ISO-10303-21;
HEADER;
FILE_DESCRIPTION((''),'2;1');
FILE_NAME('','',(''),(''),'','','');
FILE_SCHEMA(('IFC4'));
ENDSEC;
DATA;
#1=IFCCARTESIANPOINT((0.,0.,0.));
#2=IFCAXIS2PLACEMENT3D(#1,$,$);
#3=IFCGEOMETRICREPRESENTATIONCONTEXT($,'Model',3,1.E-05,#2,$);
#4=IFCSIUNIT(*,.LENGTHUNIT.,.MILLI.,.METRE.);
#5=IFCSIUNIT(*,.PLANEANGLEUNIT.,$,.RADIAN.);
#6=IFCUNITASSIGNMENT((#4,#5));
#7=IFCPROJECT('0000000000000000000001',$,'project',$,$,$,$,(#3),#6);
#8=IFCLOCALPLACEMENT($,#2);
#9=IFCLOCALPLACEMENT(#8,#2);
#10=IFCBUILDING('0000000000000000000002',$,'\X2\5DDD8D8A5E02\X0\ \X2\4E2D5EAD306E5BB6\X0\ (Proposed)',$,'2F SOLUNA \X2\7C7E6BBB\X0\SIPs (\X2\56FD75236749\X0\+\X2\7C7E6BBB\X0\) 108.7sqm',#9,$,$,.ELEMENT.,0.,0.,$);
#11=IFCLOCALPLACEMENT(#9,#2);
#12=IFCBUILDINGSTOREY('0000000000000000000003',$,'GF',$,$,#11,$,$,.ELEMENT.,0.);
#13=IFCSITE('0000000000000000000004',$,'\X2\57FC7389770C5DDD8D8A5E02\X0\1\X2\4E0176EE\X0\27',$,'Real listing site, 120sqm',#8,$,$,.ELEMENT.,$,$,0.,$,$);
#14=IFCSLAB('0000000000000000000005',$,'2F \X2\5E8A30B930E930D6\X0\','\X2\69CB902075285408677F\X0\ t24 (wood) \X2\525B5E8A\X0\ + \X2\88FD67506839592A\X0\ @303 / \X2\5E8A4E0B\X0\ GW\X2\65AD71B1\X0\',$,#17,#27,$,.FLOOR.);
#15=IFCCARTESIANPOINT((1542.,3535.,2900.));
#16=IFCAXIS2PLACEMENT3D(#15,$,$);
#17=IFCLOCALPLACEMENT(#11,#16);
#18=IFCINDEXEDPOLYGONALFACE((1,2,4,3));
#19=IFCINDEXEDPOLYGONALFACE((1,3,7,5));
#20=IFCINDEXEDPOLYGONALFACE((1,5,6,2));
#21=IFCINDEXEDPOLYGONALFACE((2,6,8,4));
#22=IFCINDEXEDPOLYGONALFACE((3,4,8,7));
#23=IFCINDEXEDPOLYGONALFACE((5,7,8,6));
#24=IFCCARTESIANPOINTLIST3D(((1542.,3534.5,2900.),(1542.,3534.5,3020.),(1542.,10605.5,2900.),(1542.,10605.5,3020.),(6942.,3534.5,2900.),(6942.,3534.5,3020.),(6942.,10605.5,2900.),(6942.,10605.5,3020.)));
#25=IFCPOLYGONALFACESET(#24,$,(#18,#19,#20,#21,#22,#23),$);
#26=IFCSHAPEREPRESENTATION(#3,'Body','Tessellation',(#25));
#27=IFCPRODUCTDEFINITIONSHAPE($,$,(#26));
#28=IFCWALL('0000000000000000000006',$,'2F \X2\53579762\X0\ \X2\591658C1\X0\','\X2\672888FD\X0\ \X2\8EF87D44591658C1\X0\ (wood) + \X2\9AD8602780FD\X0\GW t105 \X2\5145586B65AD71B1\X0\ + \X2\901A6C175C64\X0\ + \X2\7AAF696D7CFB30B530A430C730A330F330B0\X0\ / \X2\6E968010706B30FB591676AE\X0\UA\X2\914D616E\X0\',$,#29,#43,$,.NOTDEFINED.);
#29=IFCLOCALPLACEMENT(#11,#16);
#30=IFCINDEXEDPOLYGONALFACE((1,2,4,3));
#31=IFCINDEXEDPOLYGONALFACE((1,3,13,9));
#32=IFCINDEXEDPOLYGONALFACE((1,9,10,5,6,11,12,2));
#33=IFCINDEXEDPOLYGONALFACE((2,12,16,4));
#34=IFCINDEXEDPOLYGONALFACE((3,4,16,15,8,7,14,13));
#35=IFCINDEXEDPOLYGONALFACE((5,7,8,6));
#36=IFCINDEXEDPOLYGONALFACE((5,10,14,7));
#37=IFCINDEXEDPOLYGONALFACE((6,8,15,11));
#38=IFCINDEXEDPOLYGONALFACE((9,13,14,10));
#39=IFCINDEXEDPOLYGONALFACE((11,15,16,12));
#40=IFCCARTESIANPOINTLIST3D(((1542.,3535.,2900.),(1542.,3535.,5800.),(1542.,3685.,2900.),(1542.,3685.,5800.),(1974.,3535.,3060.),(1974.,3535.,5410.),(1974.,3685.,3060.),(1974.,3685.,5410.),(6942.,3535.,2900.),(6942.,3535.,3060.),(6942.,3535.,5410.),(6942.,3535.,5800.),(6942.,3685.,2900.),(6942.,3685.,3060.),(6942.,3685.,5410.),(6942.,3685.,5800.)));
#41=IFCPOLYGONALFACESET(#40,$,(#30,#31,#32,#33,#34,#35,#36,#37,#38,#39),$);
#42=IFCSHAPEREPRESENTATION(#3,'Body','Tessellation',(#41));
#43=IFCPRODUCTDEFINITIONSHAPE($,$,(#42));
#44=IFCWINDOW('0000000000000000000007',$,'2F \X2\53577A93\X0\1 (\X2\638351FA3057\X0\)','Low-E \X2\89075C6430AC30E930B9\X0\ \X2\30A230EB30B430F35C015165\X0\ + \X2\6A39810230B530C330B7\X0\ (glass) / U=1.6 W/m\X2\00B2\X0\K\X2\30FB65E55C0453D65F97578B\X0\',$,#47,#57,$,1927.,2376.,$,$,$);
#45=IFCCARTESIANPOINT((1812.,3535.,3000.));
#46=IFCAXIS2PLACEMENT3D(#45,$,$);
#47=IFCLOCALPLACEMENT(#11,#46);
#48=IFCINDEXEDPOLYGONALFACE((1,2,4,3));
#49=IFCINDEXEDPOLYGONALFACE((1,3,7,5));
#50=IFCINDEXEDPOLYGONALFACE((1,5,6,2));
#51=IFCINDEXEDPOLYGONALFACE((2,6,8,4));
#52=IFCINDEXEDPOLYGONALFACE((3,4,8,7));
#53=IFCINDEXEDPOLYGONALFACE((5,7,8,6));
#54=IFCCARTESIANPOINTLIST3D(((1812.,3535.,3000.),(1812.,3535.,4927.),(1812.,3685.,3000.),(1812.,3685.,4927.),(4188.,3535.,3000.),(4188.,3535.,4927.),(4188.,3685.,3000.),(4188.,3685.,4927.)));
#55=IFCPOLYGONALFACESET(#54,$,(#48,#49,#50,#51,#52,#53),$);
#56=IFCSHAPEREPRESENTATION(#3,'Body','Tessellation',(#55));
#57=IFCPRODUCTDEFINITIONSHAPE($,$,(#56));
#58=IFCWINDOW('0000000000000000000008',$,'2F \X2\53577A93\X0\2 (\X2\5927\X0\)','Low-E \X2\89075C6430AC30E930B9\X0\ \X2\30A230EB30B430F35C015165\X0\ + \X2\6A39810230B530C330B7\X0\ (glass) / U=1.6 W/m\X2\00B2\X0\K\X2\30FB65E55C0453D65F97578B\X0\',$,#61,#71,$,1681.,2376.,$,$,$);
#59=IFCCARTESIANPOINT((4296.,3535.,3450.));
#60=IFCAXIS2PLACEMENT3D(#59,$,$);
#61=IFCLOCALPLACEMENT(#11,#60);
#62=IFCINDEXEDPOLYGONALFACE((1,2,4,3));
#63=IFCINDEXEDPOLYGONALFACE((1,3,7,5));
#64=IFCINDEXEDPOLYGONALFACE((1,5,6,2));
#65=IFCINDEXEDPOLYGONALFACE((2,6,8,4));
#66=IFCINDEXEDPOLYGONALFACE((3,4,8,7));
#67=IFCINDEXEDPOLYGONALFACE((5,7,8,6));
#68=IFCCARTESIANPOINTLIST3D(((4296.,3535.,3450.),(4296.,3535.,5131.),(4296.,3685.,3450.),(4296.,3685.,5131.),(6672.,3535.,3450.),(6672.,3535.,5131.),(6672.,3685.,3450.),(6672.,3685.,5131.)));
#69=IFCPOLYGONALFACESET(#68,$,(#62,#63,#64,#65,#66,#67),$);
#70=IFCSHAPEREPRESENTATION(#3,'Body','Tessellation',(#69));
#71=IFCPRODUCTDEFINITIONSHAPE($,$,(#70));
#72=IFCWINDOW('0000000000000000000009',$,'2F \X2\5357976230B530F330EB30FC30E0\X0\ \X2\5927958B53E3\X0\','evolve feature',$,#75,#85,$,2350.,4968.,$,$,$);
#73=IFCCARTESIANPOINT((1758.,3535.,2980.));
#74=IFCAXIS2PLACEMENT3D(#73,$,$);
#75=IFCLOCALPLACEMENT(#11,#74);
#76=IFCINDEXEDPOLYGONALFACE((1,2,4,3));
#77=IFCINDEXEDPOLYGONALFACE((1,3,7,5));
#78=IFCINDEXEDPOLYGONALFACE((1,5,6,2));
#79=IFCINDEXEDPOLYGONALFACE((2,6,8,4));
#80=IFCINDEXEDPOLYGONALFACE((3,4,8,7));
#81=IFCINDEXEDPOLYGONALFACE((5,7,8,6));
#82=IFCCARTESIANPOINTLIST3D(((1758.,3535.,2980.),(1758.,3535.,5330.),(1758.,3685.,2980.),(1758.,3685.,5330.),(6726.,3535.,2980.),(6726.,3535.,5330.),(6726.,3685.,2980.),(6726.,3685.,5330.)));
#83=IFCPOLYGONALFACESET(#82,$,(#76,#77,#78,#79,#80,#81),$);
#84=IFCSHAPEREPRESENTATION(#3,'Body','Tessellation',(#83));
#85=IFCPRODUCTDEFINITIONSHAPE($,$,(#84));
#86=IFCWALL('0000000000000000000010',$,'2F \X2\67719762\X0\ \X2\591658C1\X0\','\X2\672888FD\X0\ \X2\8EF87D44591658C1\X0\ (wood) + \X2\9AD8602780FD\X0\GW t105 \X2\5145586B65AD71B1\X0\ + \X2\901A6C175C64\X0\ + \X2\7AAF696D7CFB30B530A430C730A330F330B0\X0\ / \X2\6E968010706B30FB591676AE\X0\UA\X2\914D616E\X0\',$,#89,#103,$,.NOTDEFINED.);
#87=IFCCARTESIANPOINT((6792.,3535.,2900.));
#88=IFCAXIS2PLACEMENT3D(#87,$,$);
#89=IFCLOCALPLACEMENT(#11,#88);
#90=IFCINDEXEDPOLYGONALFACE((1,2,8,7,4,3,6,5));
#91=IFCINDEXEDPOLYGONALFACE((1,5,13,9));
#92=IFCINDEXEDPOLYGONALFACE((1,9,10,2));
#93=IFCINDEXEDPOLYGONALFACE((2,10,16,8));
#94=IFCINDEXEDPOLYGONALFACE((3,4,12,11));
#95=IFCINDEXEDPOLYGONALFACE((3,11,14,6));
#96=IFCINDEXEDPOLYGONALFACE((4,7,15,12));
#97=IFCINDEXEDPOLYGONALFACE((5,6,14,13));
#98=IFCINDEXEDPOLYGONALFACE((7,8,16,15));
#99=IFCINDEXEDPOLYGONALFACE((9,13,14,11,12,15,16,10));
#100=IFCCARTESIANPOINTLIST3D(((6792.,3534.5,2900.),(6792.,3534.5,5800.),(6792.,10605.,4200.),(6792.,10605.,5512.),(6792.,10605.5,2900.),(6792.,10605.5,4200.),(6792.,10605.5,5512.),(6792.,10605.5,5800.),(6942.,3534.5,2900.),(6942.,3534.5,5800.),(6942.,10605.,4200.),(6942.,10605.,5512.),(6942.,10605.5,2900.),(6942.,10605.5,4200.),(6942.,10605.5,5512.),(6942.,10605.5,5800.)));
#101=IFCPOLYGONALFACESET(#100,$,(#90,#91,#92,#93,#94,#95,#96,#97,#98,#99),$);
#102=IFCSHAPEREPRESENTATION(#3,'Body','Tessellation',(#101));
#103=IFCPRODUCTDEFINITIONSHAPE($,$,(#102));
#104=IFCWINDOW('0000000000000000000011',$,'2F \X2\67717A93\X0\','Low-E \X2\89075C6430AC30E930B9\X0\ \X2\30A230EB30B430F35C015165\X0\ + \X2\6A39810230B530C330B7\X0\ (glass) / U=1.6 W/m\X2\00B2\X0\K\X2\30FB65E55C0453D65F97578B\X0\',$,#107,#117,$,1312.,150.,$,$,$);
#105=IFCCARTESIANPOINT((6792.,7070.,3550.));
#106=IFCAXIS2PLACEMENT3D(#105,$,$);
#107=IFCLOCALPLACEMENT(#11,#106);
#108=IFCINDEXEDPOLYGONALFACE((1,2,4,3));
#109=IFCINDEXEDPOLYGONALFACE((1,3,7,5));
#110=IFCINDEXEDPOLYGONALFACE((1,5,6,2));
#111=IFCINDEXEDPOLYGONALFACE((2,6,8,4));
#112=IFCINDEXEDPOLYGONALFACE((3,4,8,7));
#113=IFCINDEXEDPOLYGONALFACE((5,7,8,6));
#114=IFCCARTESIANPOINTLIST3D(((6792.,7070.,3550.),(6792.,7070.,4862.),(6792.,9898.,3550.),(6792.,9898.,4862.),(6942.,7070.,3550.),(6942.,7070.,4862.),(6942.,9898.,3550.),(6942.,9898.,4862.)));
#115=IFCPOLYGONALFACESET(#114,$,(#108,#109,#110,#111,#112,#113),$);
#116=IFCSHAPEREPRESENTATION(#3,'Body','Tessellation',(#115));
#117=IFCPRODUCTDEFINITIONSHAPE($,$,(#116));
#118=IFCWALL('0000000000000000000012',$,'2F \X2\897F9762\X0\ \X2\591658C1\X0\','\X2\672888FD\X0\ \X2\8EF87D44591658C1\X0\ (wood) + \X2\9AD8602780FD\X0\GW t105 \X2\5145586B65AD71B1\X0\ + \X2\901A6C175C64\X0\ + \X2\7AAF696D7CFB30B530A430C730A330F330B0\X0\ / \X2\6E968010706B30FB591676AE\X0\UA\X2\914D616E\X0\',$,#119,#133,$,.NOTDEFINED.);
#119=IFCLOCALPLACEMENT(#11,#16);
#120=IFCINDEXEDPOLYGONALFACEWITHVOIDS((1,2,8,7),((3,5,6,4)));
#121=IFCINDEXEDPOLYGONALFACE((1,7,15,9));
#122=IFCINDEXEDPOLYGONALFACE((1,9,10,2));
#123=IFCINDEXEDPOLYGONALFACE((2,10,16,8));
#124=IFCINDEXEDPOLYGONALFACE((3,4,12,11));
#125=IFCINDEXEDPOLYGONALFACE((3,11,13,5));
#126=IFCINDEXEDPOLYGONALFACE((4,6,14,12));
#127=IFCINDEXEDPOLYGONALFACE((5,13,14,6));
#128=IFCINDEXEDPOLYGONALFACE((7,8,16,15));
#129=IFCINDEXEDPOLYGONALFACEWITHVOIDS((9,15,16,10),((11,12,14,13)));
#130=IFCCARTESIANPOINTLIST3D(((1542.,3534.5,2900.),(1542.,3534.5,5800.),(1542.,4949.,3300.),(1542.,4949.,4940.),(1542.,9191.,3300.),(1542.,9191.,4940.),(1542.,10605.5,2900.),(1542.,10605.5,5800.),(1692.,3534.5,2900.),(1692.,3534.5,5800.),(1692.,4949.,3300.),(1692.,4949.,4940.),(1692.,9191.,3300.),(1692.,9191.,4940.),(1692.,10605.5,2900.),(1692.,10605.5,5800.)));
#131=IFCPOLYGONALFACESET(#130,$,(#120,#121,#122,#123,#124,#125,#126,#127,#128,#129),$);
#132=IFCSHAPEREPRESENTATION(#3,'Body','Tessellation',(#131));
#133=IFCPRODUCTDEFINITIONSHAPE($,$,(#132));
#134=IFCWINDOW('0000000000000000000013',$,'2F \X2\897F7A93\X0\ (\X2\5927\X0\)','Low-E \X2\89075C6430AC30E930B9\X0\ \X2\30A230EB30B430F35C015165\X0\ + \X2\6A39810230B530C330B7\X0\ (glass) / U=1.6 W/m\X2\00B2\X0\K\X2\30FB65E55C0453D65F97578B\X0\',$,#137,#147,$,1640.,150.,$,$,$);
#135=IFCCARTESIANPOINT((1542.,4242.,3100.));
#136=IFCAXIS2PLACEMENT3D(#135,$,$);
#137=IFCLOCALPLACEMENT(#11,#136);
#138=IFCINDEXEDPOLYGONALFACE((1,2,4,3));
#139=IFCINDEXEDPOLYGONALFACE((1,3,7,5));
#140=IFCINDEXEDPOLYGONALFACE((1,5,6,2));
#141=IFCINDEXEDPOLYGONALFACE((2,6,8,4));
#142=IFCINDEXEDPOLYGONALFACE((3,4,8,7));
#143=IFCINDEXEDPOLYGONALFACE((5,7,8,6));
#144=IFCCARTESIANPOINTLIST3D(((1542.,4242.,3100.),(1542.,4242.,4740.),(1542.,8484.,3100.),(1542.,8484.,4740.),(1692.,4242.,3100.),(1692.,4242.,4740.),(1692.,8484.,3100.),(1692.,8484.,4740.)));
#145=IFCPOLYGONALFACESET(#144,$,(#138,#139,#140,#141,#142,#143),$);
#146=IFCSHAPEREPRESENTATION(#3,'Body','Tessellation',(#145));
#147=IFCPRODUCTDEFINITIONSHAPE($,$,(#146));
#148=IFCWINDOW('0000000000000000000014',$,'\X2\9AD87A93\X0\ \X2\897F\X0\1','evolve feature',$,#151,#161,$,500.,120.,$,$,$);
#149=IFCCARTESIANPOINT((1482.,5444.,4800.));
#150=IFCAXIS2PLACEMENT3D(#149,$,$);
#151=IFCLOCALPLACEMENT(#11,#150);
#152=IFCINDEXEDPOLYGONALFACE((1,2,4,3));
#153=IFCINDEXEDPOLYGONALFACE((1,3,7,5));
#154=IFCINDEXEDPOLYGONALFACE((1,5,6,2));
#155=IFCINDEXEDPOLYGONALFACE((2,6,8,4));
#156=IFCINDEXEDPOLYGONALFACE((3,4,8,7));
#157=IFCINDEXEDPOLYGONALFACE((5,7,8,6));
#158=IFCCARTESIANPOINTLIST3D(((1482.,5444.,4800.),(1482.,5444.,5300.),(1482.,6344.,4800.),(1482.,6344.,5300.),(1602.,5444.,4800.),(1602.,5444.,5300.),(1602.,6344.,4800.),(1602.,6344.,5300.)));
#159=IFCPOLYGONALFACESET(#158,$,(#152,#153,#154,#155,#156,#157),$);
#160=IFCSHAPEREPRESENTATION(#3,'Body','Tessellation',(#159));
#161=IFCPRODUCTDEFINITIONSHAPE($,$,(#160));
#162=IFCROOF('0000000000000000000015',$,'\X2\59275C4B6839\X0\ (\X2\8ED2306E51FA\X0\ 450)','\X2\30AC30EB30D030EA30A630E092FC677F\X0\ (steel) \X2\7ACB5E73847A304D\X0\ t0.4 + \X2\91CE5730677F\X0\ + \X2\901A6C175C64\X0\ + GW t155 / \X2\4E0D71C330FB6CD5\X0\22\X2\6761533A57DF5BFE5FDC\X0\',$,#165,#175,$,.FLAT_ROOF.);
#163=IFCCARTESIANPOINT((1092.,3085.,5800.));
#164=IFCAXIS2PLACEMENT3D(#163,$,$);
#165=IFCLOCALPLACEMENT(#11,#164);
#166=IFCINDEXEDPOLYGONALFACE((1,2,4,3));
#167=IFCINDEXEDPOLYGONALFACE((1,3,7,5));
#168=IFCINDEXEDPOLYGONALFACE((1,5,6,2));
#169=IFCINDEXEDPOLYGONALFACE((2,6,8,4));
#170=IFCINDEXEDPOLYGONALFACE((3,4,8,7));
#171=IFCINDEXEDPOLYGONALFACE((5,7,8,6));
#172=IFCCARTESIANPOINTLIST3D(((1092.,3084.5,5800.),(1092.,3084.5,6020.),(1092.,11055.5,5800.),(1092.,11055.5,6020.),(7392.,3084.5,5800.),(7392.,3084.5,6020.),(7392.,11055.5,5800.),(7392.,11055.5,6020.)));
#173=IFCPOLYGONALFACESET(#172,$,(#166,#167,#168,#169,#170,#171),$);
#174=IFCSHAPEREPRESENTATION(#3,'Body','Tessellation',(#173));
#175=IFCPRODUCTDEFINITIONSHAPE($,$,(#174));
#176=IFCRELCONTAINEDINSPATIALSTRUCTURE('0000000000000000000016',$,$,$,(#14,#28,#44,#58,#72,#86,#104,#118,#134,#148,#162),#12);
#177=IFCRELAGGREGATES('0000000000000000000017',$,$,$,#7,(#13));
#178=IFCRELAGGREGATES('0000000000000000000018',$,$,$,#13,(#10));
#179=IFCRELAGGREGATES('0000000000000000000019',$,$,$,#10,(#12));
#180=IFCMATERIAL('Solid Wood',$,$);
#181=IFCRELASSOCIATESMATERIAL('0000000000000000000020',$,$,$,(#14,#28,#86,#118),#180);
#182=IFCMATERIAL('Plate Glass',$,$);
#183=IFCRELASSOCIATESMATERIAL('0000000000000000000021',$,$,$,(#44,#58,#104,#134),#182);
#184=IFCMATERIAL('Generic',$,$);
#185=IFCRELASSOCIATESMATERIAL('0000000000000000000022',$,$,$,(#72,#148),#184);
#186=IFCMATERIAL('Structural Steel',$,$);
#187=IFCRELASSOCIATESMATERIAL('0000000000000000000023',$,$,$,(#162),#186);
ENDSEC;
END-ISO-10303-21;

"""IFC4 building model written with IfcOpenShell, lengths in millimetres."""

from ifc_helpers import new_model, si_unit, frame, frame_2d, origin, place, context, project, spatial, rectangle, extrude, material, element, fill, save


model = new_model("IFC4")

# Units and contexts
model_context = context("Model", 3, precision=1e-05, world=origin())
ifc_project = project(units=[si_unit("LENGTHUNIT", "METRE", prefix="MILLI"), si_unit("PLANEANGLEUNIT", "RADIAN")], contexts=[model_context])

# Site, building, storey
site_placement = place(None, origin())
site = spatial("IfcSite", under=ifc_project, at=site_placement, Name="埼玉県川越市1丁目27", ObjectType="Real listing site, 120sqm", CompositionType="ELEMENT", RefElevation=0.0)
building_placement = place(site_placement, origin())
building = spatial("IfcBuilding", under=site, at=building_placement, Name="川越市 中庭の家 (Proposed)", ObjectType="2F SOLUNA 籾殻SIPs (国産杉+籾殻) 108.7sqm", CompositionType="ELEMENT", ElevationOfRefHeight=0.0, ElevationOfTerrain=0.0)
storey_placement = place(building_placement, origin())
storey = spatial("IfcBuildingStorey", under=building, at=storey_placement, Name="GF", CompositionType="ELEMENT", Elevation=0.0)

# Slab
ifc_material_1 = material(Name="Solid Wood")
slab_placement = place(storey_placement, frame((1542.0, 3535.0, 2900.0)))
element("IfcSlab", 1, at=slab_placement, inside=storey, material=ifc_material_1, Name="2F 床スラブ", Description="構造用合板 t24 (wood) 剛床 + 製材根太 @303 / 床下 GW断熱", PredefinedType="FLOOR", context=model_context, shape_type="SweptSolid", body=[
    extrude(rectangle(XDim=5400.0, YDim=7071.0, at=frame_2d((2700.0, 3535.0))), frame((1542.0, 3535.0, 2900.0)), (0.0, 0.0, 1.0), 120.0),
])

# Wall, openings, windows
wall_1_placement = place(storey_placement, frame((1542.0, 3535.0, 2900.0)))
wall_1 = element("IfcWall", 2, at=wall_1_placement, inside=storey, material=ifc_material_1, Name="2F 南面 外壁", Description="木製 軸組外壁 (wood) + 高性能GW t105 充填断熱 + 通気層 + 窯業系サイディング / 準耐火・外皮UA配慮", PredefinedType="NOTDEFINED", context=model_context, shape_type="SweptSolid", body=[
    extrude(rectangle(XDim=5400.0, YDim=150.0, at=frame_2d((2700.0, 75.0))), frame((1542.0, 3535.0, 2900.0)), (0.0, 0.0, 1.0), 2900.0),
])
opening_1_placement = place(storey_placement, frame((1812.0, 3535.0, 3000.0)))
opening_1 = element("IfcOpeningElement", 3, at=opening_1_placement, cuts=wall_1, PredefinedType="NOTDEFINED", context=model_context, shape_type="SweptSolid", body=[
    extrude(rectangle(XDim=2376.0, YDim=150.0, at=frame_2d((1188.0, 75.0))), frame((1812.0, 3535.0, 3000.0)), (0.0, 0.0, 1.0), 1927.0),
])
opening_2_placement = place(storey_placement, frame((4296.0, 3535.0, 3450.0)))
opening_2 = element("IfcOpeningElement", 4, at=opening_2_placement, cuts=wall_1, PredefinedType="NOTDEFINED", context=model_context, shape_type="SweptSolid", body=[
    extrude(rectangle(XDim=2376.0, YDim=150.0, at=frame_2d((1188.0, 75.0))), frame((4296.0, 3535.0, 3450.0)), (0.0, 0.0, 1.0), 1681.0),
])
opening_3_placement = place(storey_placement, frame((1758.0, 3535.0, 2980.0)))
opening_3 = element("IfcOpeningElement", 5, at=opening_3_placement, cuts=wall_1, PredefinedType="NOTDEFINED", context=model_context, shape_type="SweptSolid", body=[
    extrude(rectangle(XDim=4968.0, YDim=150.0, at=frame_2d((2484.0, 75.0))), frame((1758.0, 3535.0, 2980.0)), (0.0, 0.0, 1.0), 2350.0),
])
ifc_material_2 = material(Name="Plate Glass")
window_1_placement = place(storey_placement, frame((1812.0, 3535.0, 3000.0)))
window_1 = element("IfcWindow", 6, at=window_1_placement, inside=storey, material=ifc_material_2, Name="2F 南窓1 (掃出し)", Description="Low-E 複層ガラス アルゴン封入 + 樹脂サッシ (glass) / U=1.6 W/m²K・日射取得型", OverallHeight=1927.0, OverallWidth=2376.0, context=model_context, shape_type="SweptSolid", body=[
    extrude(rectangle(XDim=2376.0, YDim=150.0, at=frame_2d((1188.0, 75.0))), frame((1812.0, 3535.0, 3000.0)), (0.0, 0.0, 1.0), 1927.0),
])
fill(opening_1, window_1)
window_2_placement = place(storey_placement, frame((4296.0, 3535.0, 3450.0)))
window_2 = element("IfcWindow", 7, at=window_2_placement, inside=storey, material=ifc_material_2, Name="2F 南窓2 (大)", Description="Low-E 複層ガラス アルゴン封入 + 樹脂サッシ (glass) / U=1.6 W/m²K・日射取得型", OverallHeight=1681.0, OverallWidth=2376.0, context=model_context, shape_type="SweptSolid", body=[
    extrude(rectangle(XDim=2376.0, YDim=150.0, at=frame_2d((1188.0, 75.0))), frame((4296.0, 3535.0, 3450.0)), (0.0, 0.0, 1.0), 1681.0),
])
fill(opening_2, window_2)
ifc_material_3 = material(Name="Generic")
window_3_placement = place(storey_placement, frame((1758.0, 3535.0, 2980.0)))
window_3 = element("IfcWindow", 8, at=window_3_placement, inside=storey, material=ifc_material_3, Name="2F 南面サンルーム 大開口", Description="evolve feature", OverallHeight=2350.0, OverallWidth=4968.0, context=model_context, shape_type="SweptSolid", body=[
    extrude(rectangle(XDim=4968.0, YDim=150.0, at=frame_2d((2484.0, 75.0))), frame((1758.0, 3535.0, 2980.0)), (0.0, 0.0, 1.0), 2350.0),
])
fill(opening_3, window_3)

# Wall, opening, window
wall_2_placement = place(storey_placement, frame((6792.0, 3535.0, 2900.0)))
wall_2 = element("IfcWall", 9, at=wall_2_placement, inside=storey, material=ifc_material_1, Name="2F 東面 外壁", Description="木製 軸組外壁 (wood) + 高性能GW t105 充填断熱 + 通気層 + 窯業系サイディング / 準耐火・外皮UA配慮", PredefinedType="NOTDEFINED", context=model_context, shape_type="SweptSolid", body=[
    extrude(rectangle(XDim=150.0, YDim=7071.0, at=frame_2d((75.0, 3535.0))), frame((6792.0, 3535.0, 2900.0)), (0.0, 0.0, 1.0), 2900.0),
])
opening_4_placement = place(storey_placement, frame((6792.0, 7070.0, 3550.0)))
opening_4 = element("IfcOpeningElement", 10, at=opening_4_placement, cuts=wall_2, PredefinedType="NOTDEFINED", context=model_context, shape_type="SweptSolid", body=[
    extrude(rectangle(XDim=150.0, YDim=2828.0, at=frame_2d((75.0, 1414.0))), frame((6792.0, 7070.0, 3550.0)), (0.0, 0.0, 1.0), 1312.0),
])
window_4_placement = place(storey_placement, frame((6792.0, 7070.0, 3550.0)))
window_4 = element("IfcWindow", 11, at=window_4_placement, inside=storey, material=ifc_material_2, Name="2F 東窓", Description="Low-E 複層ガラス アルゴン封入 + 樹脂サッシ (glass) / U=1.6 W/m²K・日射取得型", OverallHeight=1312.0, OverallWidth=150.0, context=model_context, shape_type="SweptSolid", body=[
    extrude(rectangle(XDim=150.0, YDim=2828.0, at=frame_2d((75.0, 1414.0))), frame((6792.0, 7070.0, 3550.0)), (0.0, 0.0, 1.0), 1312.0),
])
fill(opening_4, window_4)

# Wall, openings, windows
wall_3_placement = place(storey_placement, frame((1542.0, 3535.0, 2900.0)))
wall_3 = element("IfcWall", 12, at=wall_3_placement, inside=storey, material=ifc_material_1, Name="2F 西面 外壁", Description="木製 軸組外壁 (wood) + 高性能GW t105 充填断熱 + 通気層 + 窯業系サイディング / 準耐火・外皮UA配慮", PredefinedType="NOTDEFINED", context=model_context, shape_type="SweptSolid", body=[
    extrude(rectangle(XDim=150.0, YDim=7071.0, at=frame_2d((75.0, 3535.0))), frame((1542.0, 3535.0, 2900.0)), (0.0, 0.0, 1.0), 2900.0),
])
opening_5_placement = place(storey_placement, frame((1542.0, 4242.0, 3100.0)))
opening_5 = element("IfcOpeningElement", 13, at=opening_5_placement, cuts=wall_3, PredefinedType="NOTDEFINED", context=model_context, shape_type="SweptSolid", body=[
    extrude(rectangle(XDim=150.0, YDim=4242.0, at=frame_2d((75.0, 2121.0))), frame((1542.0, 4242.0, 3100.0)), (0.0, 0.0, 1.0), 1640.0),
])
opening_6_placement = place(storey_placement, frame((1482.0, 5444.0, 4800.0)))
opening_6 = element("IfcOpeningElement", 14, at=opening_6_placement, cuts=wall_3, PredefinedType="NOTDEFINED", context=model_context, shape_type="SweptSolid", body=[
    extrude(rectangle(XDim=120.0, YDim=900.0, at=frame_2d((60.0, 450.0))), frame((1482.0, 5444.0, 4800.0)), (0.0, 0.0, 1.0), 500.0),
])
window_5_placement = place(storey_placement, frame((1542.0, 4242.0, 3100.0)))
window_5 = element("IfcWindow", 15, at=window_5_placement, inside=storey, material=ifc_material_2, Name="2F 西窓 (大)", Description="Low-E 複層ガラス アルゴン封入 + 樹脂サッシ (glass) / U=1.6 W/m²K・日射取得型", OverallHeight=1640.0, OverallWidth=150.0, context=model_context, shape_type="SweptSolid", body=[
    extrude(rectangle(XDim=150.0, YDim=4242.0, at=frame_2d((75.0, 2121.0))), frame((1542.0, 4242.0, 3100.0)), (0.0, 0.0, 1.0), 1640.0),
])
fill(opening_5, window_5)
window_6_placement = place(storey_placement, frame((1482.0, 5444.0, 4800.0)))
window_6 = element("IfcWindow", 16, at=window_6_placement, inside=storey, material=ifc_material_3, Name="高窓 西1", Description="evolve feature", OverallHeight=500.0, OverallWidth=120.0, context=model_context, shape_type="SweptSolid", body=[
    extrude(rectangle(XDim=120.0, YDim=900.0, at=frame_2d((60.0, 450.0))), frame((1482.0, 5444.0, 4800.0)), (0.0, 0.0, 1.0), 500.0),
])
fill(opening_6, window_6)

# Roof
ifc_material_4 = material(Name="Structural Steel")
roof_1_placement = place(storey_placement, frame((1092.0, 3085.0, 5800.0)))
element("IfcRoof", 17, at=roof_1_placement, inside=storey, material=ifc_material_4, Name="大屋根 (軒の出 450)", Description="ガルバリウム鋼板 (steel) 立平葺き t0.4 + 野地板 + 通気層 + GW t155 / 不燃・法22条区域対応", PredefinedType="FLAT_ROOF", context=model_context, shape_type="SweptSolid", body=[
    extrude(rectangle(XDim=6300.0, YDim=7971.0, at=frame_2d((3150.0, 3985.0))), frame((1092.0, 3085.0, 5800.0)), (0.0, 0.0, 1.0), 220.0),
])

save(model, "model.ifc")
